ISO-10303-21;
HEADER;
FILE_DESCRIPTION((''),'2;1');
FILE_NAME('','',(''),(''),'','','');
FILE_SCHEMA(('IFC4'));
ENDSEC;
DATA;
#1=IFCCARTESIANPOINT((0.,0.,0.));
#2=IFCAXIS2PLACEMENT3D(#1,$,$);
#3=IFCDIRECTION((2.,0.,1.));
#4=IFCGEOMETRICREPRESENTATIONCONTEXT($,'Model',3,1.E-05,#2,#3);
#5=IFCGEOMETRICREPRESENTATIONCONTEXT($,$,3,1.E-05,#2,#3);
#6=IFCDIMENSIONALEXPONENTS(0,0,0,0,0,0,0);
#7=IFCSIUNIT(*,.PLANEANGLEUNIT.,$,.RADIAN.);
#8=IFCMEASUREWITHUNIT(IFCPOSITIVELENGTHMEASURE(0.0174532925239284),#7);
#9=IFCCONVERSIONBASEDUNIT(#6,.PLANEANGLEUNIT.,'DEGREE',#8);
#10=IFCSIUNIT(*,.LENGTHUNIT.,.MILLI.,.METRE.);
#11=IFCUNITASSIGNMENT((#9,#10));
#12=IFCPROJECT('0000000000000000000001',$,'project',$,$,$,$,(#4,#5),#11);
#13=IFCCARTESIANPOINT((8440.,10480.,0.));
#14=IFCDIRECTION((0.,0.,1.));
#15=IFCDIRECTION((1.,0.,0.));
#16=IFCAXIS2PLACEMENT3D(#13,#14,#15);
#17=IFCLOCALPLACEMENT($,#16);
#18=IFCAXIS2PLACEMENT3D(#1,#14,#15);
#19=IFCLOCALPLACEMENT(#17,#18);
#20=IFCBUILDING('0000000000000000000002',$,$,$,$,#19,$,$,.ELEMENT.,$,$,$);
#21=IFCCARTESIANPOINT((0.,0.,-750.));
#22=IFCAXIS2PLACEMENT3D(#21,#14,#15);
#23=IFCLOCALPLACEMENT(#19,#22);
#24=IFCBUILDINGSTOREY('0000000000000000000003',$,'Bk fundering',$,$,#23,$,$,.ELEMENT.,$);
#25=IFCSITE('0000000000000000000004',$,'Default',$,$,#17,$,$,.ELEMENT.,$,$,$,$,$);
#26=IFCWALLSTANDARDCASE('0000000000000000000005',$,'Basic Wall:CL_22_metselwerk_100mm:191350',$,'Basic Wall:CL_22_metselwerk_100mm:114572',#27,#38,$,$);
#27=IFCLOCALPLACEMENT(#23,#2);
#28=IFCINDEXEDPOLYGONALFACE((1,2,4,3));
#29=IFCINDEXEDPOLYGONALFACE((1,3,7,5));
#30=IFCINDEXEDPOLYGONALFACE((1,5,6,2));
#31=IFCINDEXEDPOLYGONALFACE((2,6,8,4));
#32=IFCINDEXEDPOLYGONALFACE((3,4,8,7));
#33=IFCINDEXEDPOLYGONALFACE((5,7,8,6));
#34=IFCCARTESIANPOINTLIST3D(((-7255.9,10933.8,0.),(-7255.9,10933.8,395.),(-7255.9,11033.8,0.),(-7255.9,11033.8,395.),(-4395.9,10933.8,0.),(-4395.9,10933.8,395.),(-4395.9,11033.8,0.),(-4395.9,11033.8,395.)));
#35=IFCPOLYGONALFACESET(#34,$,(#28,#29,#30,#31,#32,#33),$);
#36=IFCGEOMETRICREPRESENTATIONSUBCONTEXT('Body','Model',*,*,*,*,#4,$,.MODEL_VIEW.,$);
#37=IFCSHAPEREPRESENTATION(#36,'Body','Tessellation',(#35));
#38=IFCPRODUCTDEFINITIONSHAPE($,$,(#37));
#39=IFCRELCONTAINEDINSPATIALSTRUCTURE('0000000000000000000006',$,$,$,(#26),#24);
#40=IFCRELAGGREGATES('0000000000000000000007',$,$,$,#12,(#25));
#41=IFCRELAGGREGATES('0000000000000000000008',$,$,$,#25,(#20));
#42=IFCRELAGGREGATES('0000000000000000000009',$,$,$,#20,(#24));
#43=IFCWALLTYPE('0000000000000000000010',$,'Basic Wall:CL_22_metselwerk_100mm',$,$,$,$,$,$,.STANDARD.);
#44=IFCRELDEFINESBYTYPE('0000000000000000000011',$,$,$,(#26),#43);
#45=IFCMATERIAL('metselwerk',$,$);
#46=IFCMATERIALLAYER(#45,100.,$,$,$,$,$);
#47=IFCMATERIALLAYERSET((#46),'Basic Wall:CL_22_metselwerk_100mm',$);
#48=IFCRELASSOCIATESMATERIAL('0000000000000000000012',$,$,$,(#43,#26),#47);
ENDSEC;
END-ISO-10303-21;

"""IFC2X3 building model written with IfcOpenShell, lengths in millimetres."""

from ifc_helpers import new_model, entity, si_unit, converted_unit, direction, frame, frame_2d, origin, origin_with_axes, place, context, subcontext, project, spatial, rectangle, extrude, material, layer, layer_set, layer_usage, type_object, element, save


model = new_model("IFC2X3")

# Units and contexts
model_context = context("Model", 3, precision=1e-05, world=origin(), true_north=direction((2.0, 0.0, 1.0)))
context_of_model = context(None, 3, precision=1e-05, world=origin(), true_north=direction((2.0, 0.0, 1.0)))
body_context = subcontext(model_context, "Body", "Model", "MODEL_VIEW")
ifc_project = project(units=[converted_unit("PLANEANGLEUNIT", "DEGREE", entity("IfcPositiveLengthMeasure", 0.0174532925239284), si_unit("PLANEANGLEUNIT", "RADIAN"), dimensions=[0, 0, 0, 0, 0, 0, 0]), si_unit("LENGTHUNIT", "METRE", prefix="MILLI")], contexts=[model_context, context_of_model])

# Site, building, storey
site_placement = place(None, frame((8440.0, 10480.0, 0.0), z_axis=(0.0, 0.0, 1.0), x_axis=(1.0, 0.0, 0.0)))
site = spatial("IfcSite", under=ifc_project, at=site_placement, Name="Default", CompositionType="ELEMENT")
building_placement = place(site_placement, origin_with_axes())
building = spatial("IfcBuilding", under=site, at=building_placement, CompositionType="ELEMENT")
storey_placement = place(building_placement, frame((0.0, 0.0, -750.0), z_axis=(0.0, 0.0, 1.0), x_axis=(1.0, 0.0, 0.0)))
storey = spatial("IfcBuildingStorey", under=building, at=storey_placement, Name="Bk fundering", CompositionType="ELEMENT")

# Shared definitions
ifc_material_1 = material(Name="metselwerk")

# Wall
ifc_layer_1 = layer(ifc_material_1, 100.0)
ifc_layer_set_1 = layer_set([ifc_layer_1], Name="Basic Wall:CL_22_metselwerk_100mm")
ifc_layer_usage_1 = layer_usage(ifc_layer_set_1, "AXIS2", "NEGATIVE", 50.0)
wall_type_1 = type_object("IfcWallType", Name="Basic Wall:CL_22_metselwerk_100mm", PredefinedType="STANDARD", material=ifc_layer_set_1)
wall_1_placement = place(storey_placement, frame((-4395.9, 10983.8, 0.0), z_axis=(0.0, 0.0, 1.0), x_axis=(-1.0, 0.0, 0.0)))
element("IfcWallStandardCase", 1, at=wall_1_placement, inside=storey, type_object=wall_type_1, material=ifc_layer_usage_1, Name="Basic Wall:CL_22_metselwerk_100mm:191350", ObjectType="Basic Wall:CL_22_metselwerk_100mm:114572", context=body_context, shape_type="SweptSolid", body=[
    extrude(rectangle(XDim=2860.0, YDim=100.0, at=frame_2d((1430.0, 0.0), x_axis=(-1.0, 0.0))), origin(), (0.0, 0.0, 1.0), 395.0),
])

save(model, "model.ifc")
